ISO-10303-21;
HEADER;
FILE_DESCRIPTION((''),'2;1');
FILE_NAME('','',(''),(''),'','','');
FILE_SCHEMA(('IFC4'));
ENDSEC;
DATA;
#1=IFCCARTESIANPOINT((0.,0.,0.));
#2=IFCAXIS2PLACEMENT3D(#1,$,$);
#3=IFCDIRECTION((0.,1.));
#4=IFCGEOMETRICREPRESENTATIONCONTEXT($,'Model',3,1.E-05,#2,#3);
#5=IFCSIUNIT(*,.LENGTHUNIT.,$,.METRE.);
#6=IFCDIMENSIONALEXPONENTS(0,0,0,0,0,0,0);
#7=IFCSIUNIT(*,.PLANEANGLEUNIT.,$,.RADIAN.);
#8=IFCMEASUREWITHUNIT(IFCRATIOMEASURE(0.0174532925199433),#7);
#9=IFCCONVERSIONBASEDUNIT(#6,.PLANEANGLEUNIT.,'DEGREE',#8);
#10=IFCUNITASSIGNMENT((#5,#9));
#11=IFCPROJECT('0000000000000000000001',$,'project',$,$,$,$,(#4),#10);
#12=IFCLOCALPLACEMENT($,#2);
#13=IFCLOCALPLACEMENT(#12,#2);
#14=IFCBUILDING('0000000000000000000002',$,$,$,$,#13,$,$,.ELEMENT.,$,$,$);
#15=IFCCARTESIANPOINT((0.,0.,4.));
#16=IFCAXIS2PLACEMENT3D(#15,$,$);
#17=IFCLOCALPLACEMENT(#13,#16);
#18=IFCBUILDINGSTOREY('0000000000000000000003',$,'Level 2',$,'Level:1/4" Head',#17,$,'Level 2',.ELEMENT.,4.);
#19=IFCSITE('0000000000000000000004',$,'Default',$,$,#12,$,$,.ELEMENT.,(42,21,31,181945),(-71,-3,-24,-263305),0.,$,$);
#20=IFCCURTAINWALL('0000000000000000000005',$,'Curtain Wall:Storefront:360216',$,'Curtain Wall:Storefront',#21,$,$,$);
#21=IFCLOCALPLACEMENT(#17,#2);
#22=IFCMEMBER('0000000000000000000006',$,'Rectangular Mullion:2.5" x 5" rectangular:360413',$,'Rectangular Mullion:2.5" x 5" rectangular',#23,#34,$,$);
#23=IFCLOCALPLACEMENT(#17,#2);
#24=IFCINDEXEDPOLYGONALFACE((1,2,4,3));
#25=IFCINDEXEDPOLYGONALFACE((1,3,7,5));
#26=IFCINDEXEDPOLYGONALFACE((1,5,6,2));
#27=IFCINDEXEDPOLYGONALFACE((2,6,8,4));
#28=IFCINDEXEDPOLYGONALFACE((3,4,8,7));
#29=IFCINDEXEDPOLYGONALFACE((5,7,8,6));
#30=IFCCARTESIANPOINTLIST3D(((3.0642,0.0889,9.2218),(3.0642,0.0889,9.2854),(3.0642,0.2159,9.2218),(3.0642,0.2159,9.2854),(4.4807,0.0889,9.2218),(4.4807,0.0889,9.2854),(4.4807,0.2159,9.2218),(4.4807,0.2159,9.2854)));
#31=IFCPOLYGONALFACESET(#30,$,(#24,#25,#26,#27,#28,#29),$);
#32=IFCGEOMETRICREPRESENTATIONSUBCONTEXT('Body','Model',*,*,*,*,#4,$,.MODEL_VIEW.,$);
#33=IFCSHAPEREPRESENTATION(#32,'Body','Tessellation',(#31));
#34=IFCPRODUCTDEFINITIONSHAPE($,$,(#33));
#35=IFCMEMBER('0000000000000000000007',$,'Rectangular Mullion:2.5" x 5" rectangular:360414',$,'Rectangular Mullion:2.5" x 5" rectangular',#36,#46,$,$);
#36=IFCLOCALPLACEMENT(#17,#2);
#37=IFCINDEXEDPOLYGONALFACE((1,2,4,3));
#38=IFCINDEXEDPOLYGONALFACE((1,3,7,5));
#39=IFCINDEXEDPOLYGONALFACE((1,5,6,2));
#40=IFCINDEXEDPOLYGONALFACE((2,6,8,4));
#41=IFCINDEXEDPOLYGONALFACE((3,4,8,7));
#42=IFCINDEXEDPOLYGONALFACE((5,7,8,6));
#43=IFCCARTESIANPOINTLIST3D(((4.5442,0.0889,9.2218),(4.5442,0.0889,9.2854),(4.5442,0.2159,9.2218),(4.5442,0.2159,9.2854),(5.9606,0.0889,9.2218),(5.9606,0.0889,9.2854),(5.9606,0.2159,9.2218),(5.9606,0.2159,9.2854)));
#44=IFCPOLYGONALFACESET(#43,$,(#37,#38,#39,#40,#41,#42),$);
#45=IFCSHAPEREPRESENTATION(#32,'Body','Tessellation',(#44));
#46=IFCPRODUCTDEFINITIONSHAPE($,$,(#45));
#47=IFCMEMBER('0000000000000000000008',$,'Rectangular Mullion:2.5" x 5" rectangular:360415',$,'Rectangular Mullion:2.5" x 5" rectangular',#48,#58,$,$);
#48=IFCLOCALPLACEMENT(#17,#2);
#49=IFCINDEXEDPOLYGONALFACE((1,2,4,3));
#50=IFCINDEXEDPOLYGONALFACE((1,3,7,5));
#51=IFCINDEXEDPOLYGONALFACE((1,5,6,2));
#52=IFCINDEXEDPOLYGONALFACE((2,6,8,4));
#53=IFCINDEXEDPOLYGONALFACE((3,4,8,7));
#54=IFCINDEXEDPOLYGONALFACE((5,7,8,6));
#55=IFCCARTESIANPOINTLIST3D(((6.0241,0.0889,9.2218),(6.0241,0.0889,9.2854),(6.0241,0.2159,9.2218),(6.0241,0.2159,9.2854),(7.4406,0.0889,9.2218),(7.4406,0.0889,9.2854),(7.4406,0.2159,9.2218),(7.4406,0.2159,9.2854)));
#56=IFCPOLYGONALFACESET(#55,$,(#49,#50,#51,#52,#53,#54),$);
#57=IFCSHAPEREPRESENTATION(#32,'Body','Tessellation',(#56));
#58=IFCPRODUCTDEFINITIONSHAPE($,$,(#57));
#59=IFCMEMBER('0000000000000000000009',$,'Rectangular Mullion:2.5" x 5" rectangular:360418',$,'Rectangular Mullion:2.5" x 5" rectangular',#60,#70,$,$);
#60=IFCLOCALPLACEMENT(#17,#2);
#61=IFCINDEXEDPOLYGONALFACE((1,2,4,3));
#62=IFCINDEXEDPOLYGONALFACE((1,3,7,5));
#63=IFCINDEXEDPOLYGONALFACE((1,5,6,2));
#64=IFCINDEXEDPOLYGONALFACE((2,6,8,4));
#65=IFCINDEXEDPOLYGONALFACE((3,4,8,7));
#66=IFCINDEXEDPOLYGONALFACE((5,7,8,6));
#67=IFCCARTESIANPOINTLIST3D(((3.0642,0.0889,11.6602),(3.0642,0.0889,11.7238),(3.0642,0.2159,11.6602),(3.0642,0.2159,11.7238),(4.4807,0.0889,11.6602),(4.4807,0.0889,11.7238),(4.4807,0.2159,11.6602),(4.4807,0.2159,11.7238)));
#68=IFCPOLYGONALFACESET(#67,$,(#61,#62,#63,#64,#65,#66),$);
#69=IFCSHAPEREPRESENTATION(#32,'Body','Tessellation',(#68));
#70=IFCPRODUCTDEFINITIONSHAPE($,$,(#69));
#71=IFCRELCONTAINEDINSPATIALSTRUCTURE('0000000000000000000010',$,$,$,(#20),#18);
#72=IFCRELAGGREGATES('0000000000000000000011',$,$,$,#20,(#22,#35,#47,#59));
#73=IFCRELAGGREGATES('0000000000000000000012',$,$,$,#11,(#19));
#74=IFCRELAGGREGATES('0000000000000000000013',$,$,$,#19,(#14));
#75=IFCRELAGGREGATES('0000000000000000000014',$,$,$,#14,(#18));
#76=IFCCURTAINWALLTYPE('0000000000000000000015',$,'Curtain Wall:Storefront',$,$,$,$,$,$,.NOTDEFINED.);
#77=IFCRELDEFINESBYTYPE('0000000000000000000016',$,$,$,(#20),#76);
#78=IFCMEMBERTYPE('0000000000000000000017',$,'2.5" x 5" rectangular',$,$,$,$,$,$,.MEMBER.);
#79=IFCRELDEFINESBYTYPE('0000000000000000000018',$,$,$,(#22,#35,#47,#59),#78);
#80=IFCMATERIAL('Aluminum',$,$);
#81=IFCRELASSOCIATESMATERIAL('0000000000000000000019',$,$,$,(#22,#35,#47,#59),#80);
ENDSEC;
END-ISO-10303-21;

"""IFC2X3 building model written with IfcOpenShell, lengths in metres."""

from ifc_helpers import new_model, entity, si_unit, converted_unit, direction, frame, origin, origin_2d_with_axis, place, context, subcontext, project, spatial, rectangle, extrude, source, transform, mapped, material, type_object, type_shapes, element, aggregate, save


model = new_model("IFC2X3")

# Units and contexts
model_context = context("Model", 3, precision=1e-05, world=origin(), true_north=direction((0.0, 1.0)))
body_context = subcontext(model_context, "Body", "Model", "MODEL_VIEW")
ifc_project = project(units=[si_unit("LENGTHUNIT", "METRE"), converted_unit("PLANEANGLEUNIT", "DEGREE", entity("IfcRatioMeasure", 0.0174532925199433), si_unit("PLANEANGLEUNIT", "RADIAN"), dimensions=[0, 0, 0, 0, 0, 0, 0])], contexts=[model_context])

# Site, building, storey
site_placement = place(None, origin())
site = spatial("IfcSite", under=ifc_project, at=site_placement, Name="Default", CompositionType="ELEMENT", RefLatitude=(42, 21, 31, 181945), RefLongitude=(-71, -3, -24, -263305), RefElevation=0.0)
building_placement = place(site_placement, origin())
building = spatial("IfcBuilding", under=site, at=building_placement, CompositionType="ELEMENT")
storey_placement = place(building_placement, frame((0.0, 0.0, 4.0)))
storey = spatial("IfcBuildingStorey", under=building, at=storey_placement, Name="Level 2", ObjectType="Level:1/4\" Head", LongName="Level 2", CompositionType="ELEMENT", Elevation=4.0)

# Curtain wall, members
curtain_wall_type = type_object("IfcCurtainWallType", Name="Curtain Wall:Storefront", PredefinedType="NOTDEFINED")
curtain_wall_placement = place(storey_placement, frame((0.0, 0.0, -4.0)))
curtain_wall = element("IfcCurtainWall", 1, at=curtain_wall_placement, inside=storey, type_object=curtain_wall_type, Name="Curtain Wall:Storefront:360216", ObjectType="Curtain Wall:Storefront")
ifc_material_1 = material(Name="Aluminum")
member_type_1 = type_object("IfcMemberType", Name="2.5\" x 5\" rectangular", PredefinedType="MEMBER")
shared_shape_1 = source(origin(), body_context, "Body", "SweptSolid", [
    extrude(rectangle(XDim=0.127, YDim=0.0635, at=origin_2d_with_axis()), frame((0.0, 0.0, -1.4165), z_axis=(0.0, 0.0, 1.0), x_axis=(0.0, -1.0, 0.0)), (0.0, 0.0, 1.0), 1.4165),
])
type_shapes(member_type_1, [shared_shape_1])
member_1_placement = place(storey_placement, frame((4.4807, 0.1524, 9.2536), z_axis=(1.0, 0.0, 0.0), x_axis=(0.0, 0.0, 1.0)))
member_1 = element("IfcMember", 2, at=member_1_placement, type_object=member_type_1, material=ifc_material_1, Name="Rectangular Mullion:2.5\" x 5\" rectangular:360413", ObjectType="Rectangular Mullion:2.5\" x 5\" rectangular", context=body_context, shape_type="MappedRepresentation", body=[
    mapped(shared_shape_1, transform((0.0, 0.0, 0.0), scale=1.0)),
])
member_2_placement = place(storey_placement, frame((5.9606, 0.1524, 9.2536), z_axis=(1.0, 0.0, 0.0), x_axis=(0.0, 0.0, 1.0)))
member_2 = element("IfcMember", 3, at=member_2_placement, type_object=member_type_1, material=ifc_material_1, Name="Rectangular Mullion:2.5\" x 5\" rectangular:360414", ObjectType="Rectangular Mullion:2.5\" x 5\" rectangular", context=body_context, shape_type="MappedRepresentation", body=[
    mapped(shared_shape_1, transform((0.0, 0.0, 0.0), scale=1.0)),
])
member_3_placement = place(storey_placement, frame((7.4406, 0.1524, 9.2536), z_axis=(1.0, 0.0, 0.0), x_axis=(0.0, 0.0, 1.0)))
member_3 = element("IfcMember", 4, at=member_3_placement, type_object=member_type_1, material=ifc_material_1, Name="Rectangular Mullion:2.5\" x 5\" rectangular:360415", ObjectType="Rectangular Mullion:2.5\" x 5\" rectangular", context=body_context, shape_type="MappedRepresentation", body=[
    mapped(shared_shape_1, transform((0.0, 0.0, 0.0), scale=1.0)),
])
member_4_placement = place(storey_placement, frame((4.4807, 0.1524, 11.692), z_axis=(1.0, 0.0, 0.0), x_axis=(0.0, 0.0, 1.0)))
member_4 = element("IfcMember", 5, at=member_4_placement, type_object=member_type_1, material=ifc_material_1, Name="Rectangular Mullion:2.5\" x 5\" rectangular:360418", ObjectType="Rectangular Mullion:2.5\" x 5\" rectangular", context=body_context, shape_type="MappedRepresentation", body=[
    mapped(shared_shape_1, transform((0.0, 0.0, 0.0), scale=1.0)),
])
aggregate(curtain_wall, [member_1, member_2, member_3, member_4])

save(model, "model.ifc")
